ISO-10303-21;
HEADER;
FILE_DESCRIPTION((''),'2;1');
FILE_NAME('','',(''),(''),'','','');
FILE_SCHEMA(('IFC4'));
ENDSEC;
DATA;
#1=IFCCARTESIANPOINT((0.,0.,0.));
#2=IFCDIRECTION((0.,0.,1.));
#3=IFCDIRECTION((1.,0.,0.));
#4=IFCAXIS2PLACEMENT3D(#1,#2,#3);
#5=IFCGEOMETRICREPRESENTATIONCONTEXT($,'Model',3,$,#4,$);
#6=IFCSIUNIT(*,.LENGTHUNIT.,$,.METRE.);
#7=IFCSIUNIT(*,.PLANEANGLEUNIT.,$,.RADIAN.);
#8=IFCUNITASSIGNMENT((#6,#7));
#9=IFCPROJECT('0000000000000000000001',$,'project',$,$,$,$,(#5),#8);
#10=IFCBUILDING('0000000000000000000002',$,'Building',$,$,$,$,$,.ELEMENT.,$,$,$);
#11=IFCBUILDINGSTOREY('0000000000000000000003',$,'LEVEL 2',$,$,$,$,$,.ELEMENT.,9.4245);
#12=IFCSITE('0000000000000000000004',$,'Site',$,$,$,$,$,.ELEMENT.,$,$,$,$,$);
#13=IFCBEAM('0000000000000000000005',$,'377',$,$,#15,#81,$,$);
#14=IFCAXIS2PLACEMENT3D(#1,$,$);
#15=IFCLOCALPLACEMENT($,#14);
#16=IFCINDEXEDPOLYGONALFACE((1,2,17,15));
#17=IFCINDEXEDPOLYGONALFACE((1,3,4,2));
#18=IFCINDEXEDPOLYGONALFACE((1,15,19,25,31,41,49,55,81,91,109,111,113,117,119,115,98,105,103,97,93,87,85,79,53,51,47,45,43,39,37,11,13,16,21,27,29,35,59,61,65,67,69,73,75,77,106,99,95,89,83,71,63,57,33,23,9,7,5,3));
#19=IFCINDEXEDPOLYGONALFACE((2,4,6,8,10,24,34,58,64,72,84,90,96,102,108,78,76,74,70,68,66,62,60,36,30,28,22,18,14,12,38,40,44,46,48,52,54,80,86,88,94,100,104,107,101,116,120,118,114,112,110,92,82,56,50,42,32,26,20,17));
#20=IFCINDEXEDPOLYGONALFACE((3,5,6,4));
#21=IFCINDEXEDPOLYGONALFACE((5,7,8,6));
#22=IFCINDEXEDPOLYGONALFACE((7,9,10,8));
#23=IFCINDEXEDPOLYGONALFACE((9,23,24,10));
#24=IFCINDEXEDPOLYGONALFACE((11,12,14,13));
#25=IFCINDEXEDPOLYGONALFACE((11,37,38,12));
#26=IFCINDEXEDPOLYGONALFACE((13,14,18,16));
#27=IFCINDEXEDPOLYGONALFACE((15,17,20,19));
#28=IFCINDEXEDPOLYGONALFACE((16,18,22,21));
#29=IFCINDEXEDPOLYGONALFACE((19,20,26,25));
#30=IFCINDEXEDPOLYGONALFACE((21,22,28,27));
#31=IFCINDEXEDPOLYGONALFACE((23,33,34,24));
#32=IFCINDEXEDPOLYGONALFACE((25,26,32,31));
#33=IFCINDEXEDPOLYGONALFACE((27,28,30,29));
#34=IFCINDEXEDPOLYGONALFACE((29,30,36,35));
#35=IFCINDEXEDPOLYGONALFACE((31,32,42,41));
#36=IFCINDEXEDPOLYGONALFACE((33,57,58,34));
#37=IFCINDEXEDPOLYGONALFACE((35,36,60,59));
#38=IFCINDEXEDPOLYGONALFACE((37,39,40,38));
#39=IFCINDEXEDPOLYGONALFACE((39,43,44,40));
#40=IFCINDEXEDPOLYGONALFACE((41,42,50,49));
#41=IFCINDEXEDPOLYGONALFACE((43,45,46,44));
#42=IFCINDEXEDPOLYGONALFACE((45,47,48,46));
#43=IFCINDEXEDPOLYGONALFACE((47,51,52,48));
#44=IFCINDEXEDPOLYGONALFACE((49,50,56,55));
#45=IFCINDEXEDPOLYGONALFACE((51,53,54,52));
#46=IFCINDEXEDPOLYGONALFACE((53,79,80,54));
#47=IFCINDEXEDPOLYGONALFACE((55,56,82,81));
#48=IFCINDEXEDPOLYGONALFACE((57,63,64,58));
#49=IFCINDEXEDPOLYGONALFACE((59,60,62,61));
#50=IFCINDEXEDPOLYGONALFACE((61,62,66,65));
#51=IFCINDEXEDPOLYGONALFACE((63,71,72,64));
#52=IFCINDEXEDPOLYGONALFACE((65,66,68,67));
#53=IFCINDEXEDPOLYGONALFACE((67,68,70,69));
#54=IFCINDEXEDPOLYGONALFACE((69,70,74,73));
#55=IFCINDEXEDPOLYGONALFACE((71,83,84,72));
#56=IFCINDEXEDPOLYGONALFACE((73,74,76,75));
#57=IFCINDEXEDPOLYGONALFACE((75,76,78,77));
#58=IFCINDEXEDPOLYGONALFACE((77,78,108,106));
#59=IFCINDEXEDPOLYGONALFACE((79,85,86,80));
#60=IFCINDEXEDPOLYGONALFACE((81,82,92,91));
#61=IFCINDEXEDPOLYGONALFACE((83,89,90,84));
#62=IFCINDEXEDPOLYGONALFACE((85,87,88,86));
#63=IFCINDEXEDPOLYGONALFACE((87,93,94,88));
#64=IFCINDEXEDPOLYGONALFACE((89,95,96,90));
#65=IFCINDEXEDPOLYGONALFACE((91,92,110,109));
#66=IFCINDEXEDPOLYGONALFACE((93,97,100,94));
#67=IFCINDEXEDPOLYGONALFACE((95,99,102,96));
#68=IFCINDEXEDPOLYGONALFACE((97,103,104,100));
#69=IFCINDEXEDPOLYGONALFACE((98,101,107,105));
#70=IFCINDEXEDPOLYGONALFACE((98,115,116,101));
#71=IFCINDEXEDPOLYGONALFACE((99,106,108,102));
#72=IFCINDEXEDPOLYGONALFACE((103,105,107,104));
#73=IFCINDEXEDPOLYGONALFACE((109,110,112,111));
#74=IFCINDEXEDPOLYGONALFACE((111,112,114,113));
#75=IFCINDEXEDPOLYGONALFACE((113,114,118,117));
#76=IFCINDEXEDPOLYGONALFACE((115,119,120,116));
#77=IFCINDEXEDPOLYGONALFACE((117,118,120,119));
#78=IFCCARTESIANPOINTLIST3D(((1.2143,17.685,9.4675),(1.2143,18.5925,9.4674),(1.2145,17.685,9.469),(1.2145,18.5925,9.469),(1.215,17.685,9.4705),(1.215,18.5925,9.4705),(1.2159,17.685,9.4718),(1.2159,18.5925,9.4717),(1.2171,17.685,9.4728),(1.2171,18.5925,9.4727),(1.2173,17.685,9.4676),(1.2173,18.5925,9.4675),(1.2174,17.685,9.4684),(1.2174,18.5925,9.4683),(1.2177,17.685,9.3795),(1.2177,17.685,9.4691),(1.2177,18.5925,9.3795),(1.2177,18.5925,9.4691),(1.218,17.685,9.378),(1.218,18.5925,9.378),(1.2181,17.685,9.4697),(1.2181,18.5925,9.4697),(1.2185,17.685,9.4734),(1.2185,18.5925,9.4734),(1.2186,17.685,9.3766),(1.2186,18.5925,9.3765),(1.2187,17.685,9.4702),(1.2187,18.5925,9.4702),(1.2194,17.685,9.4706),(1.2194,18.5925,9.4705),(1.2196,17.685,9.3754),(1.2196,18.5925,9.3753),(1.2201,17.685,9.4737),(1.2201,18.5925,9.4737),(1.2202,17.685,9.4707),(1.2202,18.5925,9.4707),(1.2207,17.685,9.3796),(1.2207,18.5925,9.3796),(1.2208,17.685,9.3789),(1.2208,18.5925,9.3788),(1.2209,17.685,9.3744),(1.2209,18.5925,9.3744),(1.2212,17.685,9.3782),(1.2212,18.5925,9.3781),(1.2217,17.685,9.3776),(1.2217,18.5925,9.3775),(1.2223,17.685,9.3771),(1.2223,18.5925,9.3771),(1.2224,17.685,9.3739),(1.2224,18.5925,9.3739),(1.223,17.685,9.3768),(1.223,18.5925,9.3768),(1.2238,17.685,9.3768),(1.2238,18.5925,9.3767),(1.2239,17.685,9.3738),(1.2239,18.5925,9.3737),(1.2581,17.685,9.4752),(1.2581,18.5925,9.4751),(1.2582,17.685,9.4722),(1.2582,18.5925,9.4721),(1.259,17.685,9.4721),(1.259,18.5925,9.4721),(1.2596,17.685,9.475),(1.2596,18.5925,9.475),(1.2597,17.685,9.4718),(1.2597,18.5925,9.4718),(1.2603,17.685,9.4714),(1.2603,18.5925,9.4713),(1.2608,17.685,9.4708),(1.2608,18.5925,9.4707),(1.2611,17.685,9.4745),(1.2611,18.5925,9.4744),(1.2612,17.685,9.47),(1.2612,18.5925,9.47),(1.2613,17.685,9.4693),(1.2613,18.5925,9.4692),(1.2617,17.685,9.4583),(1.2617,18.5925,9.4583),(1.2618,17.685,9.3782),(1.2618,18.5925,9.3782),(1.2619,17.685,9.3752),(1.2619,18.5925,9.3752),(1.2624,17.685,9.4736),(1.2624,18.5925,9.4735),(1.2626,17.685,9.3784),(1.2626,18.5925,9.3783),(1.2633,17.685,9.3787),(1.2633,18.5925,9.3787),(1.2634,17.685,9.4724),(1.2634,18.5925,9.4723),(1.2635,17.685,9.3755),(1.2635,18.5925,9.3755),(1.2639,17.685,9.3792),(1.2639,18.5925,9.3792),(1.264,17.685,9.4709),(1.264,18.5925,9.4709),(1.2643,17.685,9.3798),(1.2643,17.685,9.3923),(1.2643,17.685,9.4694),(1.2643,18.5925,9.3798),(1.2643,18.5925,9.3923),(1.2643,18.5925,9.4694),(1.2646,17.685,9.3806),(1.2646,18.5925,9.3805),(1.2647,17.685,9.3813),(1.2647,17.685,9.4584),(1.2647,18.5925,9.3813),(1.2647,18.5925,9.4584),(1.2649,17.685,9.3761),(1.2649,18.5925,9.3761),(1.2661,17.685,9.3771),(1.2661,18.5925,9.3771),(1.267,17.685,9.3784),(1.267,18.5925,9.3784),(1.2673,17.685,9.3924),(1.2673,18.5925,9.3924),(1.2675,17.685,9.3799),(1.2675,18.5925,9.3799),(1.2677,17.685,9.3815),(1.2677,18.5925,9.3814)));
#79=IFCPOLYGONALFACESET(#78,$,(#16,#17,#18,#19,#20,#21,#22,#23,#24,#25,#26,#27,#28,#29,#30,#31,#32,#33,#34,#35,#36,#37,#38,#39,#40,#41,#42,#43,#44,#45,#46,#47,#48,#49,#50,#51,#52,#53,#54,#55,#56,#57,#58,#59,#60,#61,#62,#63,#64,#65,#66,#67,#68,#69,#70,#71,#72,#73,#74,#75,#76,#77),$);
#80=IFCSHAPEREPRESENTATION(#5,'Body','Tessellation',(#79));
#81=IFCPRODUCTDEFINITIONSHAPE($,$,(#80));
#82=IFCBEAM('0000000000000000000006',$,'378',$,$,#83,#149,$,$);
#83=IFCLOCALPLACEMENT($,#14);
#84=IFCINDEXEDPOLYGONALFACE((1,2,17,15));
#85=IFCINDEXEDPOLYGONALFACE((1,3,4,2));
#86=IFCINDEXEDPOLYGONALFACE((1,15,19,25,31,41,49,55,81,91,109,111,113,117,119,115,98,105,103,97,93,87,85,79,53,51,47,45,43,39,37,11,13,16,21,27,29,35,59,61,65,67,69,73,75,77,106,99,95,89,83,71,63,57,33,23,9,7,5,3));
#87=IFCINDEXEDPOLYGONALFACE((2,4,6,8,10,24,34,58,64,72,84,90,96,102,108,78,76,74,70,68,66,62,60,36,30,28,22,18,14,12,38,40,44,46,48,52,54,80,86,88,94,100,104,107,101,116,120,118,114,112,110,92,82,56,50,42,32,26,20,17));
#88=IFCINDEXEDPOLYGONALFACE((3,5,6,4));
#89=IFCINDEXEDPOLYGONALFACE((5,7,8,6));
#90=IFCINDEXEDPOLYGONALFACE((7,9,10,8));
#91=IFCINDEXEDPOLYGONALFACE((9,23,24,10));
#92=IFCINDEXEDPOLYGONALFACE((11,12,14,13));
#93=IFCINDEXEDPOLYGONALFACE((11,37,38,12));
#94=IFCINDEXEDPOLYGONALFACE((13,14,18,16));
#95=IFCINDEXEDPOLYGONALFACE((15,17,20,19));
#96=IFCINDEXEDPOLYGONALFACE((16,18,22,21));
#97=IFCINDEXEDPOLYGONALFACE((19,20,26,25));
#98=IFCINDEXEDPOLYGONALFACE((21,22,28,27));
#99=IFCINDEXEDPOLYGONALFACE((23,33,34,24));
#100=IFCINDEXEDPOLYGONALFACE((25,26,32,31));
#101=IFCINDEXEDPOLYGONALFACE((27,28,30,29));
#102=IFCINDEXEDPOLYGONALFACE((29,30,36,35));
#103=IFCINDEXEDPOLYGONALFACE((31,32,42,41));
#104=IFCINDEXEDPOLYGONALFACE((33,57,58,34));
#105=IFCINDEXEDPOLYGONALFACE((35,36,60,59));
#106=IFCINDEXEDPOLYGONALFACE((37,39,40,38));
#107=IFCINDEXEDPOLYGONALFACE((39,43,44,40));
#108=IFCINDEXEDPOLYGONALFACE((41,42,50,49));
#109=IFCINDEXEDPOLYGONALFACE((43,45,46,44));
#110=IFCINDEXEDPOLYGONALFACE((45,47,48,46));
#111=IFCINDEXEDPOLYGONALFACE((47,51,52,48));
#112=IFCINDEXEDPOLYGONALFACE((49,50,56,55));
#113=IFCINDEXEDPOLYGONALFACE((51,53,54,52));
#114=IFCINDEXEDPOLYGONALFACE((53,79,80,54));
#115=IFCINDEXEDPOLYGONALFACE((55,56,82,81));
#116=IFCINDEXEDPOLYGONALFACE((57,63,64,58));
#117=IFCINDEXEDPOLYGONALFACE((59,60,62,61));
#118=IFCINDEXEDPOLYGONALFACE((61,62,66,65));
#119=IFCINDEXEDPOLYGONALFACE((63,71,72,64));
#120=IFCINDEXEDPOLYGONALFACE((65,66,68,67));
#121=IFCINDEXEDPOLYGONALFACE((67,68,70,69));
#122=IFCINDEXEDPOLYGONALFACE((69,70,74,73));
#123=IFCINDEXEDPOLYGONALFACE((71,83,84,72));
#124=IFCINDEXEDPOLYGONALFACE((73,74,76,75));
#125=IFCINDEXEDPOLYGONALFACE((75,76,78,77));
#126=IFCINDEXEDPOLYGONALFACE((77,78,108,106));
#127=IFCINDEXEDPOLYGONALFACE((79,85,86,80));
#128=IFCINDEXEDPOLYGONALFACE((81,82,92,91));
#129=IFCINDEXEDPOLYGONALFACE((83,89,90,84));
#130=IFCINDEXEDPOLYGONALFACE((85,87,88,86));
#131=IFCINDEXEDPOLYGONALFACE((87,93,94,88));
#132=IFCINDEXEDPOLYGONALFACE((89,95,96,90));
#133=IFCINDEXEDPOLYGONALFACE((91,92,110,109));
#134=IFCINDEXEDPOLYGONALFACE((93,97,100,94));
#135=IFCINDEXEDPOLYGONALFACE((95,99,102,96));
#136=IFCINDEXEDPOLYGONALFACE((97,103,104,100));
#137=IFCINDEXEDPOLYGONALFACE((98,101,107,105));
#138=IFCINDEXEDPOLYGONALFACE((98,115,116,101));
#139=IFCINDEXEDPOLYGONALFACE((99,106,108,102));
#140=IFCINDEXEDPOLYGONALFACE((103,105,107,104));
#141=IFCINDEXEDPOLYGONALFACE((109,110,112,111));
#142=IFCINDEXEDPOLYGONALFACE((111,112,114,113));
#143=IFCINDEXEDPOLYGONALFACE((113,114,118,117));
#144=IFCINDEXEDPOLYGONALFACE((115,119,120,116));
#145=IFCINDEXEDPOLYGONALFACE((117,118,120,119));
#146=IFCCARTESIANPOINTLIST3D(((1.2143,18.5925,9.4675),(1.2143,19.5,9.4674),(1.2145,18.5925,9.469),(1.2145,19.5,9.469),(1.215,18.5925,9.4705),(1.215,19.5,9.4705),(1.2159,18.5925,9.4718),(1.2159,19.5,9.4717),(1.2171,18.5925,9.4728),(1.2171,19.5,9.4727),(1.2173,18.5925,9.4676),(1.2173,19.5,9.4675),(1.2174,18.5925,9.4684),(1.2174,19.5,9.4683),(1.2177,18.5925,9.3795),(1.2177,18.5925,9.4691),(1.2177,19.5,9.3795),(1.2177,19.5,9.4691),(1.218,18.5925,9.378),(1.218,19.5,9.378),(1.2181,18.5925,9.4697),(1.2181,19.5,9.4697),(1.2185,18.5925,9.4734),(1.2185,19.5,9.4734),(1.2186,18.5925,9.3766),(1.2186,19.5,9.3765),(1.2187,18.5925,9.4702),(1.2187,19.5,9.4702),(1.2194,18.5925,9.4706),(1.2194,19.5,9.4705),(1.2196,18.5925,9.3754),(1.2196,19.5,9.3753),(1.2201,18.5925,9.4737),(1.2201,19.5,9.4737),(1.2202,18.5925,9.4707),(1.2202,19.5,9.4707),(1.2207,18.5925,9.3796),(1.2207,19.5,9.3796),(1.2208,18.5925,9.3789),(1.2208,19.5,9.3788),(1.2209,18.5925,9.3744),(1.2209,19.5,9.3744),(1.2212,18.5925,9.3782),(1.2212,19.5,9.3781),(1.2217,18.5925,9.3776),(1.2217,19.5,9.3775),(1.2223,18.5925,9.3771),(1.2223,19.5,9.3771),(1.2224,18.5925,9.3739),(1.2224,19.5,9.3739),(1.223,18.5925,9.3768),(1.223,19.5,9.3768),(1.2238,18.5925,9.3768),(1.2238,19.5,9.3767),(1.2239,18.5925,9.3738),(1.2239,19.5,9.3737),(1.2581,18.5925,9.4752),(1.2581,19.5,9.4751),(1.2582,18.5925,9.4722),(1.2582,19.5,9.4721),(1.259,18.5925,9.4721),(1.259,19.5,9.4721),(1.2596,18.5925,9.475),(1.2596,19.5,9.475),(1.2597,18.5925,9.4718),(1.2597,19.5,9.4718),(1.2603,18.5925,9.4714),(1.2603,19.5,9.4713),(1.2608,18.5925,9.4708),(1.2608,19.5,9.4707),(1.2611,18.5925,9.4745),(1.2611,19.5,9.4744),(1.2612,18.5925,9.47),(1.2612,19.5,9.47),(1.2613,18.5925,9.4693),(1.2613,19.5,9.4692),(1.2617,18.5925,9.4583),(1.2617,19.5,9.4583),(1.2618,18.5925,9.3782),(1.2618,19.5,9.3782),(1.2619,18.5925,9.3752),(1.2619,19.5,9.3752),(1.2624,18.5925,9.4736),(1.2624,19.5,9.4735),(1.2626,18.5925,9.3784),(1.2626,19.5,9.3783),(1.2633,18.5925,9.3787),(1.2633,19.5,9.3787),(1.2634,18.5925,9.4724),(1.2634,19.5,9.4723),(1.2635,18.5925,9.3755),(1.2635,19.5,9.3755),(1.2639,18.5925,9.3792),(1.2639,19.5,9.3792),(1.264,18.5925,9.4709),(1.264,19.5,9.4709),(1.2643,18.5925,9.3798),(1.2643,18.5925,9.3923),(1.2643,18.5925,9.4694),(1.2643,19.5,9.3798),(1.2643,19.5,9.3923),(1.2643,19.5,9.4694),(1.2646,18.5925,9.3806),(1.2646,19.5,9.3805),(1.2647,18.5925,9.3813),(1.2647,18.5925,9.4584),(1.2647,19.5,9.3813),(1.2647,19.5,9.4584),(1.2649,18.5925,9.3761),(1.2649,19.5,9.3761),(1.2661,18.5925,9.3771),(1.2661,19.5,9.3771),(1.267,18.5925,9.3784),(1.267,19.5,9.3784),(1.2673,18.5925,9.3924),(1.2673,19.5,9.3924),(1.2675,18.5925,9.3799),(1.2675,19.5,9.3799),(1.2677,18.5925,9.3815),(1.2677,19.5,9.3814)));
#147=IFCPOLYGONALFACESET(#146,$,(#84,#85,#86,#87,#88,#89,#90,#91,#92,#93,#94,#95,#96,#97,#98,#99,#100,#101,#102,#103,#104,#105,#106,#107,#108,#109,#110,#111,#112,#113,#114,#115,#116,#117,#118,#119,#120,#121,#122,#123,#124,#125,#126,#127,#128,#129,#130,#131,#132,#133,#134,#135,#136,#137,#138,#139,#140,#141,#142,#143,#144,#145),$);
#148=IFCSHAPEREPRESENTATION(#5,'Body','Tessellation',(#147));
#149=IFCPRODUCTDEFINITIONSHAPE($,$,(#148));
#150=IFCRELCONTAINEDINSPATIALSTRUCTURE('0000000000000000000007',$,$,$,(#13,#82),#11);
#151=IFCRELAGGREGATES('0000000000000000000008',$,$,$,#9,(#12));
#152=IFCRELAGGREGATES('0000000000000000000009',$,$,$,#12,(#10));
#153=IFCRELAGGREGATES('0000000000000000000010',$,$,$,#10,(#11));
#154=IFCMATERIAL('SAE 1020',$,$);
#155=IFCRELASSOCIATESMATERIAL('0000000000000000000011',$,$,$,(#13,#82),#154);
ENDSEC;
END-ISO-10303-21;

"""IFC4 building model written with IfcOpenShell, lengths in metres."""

from ifc_helpers import new_model, si_unit, frame, origin_with_axes, origin_2d_with_axis, place, context, project, spatial, c_section, extrude, material, material_profile, profile_set, profile_usage, element, save


model = new_model("IFC4")

# Units and contexts
model_context = context("Model", 3, world=origin_with_axes())
ifc_project = project(units=[si_unit("LENGTHUNIT", "METRE"), si_unit("PLANEANGLEUNIT", "RADIAN")], contexts=[model_context])

# Site, building, storey
site = spatial("IfcSite", under=ifc_project, Name="Site", CompositionType="ELEMENT")
building = spatial("IfcBuilding", under=site, Name="Building", CompositionType="ELEMENT")
storey = spatial("IfcBuildingStorey", under=building, Name="LEVEL 2", CompositionType="ELEMENT", Elevation=9.4245)

# Beams
ifc_material = material(Name="SAE 1020")
ifc_material_profile_1 = material_profile(ifc_material, c_section(Depth=0.1, Width=0.05, WallThickness=0.003, Girth=0.017, InternalFilletRadius=0.003, at=origin_2d_with_axis()))
ifc_profile_set_1 = profile_set([ifc_material_profile_1])
ifc_profile_usage_1 = profile_usage(ifc_profile_set_1, cardinal=10)
beam_1_placement = place(None, frame((1.241, 17.685, 9.4245), z_axis=(0.0, 1.0, -0.00003), x_axis=(0.999256, 0.000001, 0.038562)))
element("IfcBeam", 1, at=beam_1_placement, inside=storey, material=ifc_profile_usage_1, Name="377", context=model_context, shape_type="SweptSolid", body=[
    extrude(c_section(Depth=0.1, Width=0.05, WallThickness=0.003, Girth=0.017, InternalFilletRadius=0.003, at=origin_2d_with_axis()), origin_with_axes(), (0.0, 0.0, 1.0), 0.9075),
])
ifc_material_profile_2 = material_profile(ifc_material, c_section(Depth=0.1, Width=0.05, WallThickness=0.003, Girth=0.017, InternalFilletRadius=0.003, at=origin_2d_with_axis()))
ifc_profile_set_2 = profile_set([ifc_material_profile_2])
ifc_profile_usage_2 = profile_usage(ifc_profile_set_2, cardinal=10)
beam_2_placement = place(None, frame((1.241, 18.5925, 9.4245), z_axis=(0.0, 1.0, -0.00003), x_axis=(0.999256, 0.000001, 0.038562)))
element("IfcBeam", 2, at=beam_2_placement, inside=storey, material=ifc_profile_usage_2, Name="378", context=model_context, shape_type="SweptSolid", body=[
    extrude(c_section(Depth=0.1, Width=0.05, WallThickness=0.003, Girth=0.017, InternalFilletRadius=0.003, at=origin_2d_with_axis()), origin_with_axes(), (0.0, 0.0, 1.0), 0.9075),
])

save(model, "model.ifc")
